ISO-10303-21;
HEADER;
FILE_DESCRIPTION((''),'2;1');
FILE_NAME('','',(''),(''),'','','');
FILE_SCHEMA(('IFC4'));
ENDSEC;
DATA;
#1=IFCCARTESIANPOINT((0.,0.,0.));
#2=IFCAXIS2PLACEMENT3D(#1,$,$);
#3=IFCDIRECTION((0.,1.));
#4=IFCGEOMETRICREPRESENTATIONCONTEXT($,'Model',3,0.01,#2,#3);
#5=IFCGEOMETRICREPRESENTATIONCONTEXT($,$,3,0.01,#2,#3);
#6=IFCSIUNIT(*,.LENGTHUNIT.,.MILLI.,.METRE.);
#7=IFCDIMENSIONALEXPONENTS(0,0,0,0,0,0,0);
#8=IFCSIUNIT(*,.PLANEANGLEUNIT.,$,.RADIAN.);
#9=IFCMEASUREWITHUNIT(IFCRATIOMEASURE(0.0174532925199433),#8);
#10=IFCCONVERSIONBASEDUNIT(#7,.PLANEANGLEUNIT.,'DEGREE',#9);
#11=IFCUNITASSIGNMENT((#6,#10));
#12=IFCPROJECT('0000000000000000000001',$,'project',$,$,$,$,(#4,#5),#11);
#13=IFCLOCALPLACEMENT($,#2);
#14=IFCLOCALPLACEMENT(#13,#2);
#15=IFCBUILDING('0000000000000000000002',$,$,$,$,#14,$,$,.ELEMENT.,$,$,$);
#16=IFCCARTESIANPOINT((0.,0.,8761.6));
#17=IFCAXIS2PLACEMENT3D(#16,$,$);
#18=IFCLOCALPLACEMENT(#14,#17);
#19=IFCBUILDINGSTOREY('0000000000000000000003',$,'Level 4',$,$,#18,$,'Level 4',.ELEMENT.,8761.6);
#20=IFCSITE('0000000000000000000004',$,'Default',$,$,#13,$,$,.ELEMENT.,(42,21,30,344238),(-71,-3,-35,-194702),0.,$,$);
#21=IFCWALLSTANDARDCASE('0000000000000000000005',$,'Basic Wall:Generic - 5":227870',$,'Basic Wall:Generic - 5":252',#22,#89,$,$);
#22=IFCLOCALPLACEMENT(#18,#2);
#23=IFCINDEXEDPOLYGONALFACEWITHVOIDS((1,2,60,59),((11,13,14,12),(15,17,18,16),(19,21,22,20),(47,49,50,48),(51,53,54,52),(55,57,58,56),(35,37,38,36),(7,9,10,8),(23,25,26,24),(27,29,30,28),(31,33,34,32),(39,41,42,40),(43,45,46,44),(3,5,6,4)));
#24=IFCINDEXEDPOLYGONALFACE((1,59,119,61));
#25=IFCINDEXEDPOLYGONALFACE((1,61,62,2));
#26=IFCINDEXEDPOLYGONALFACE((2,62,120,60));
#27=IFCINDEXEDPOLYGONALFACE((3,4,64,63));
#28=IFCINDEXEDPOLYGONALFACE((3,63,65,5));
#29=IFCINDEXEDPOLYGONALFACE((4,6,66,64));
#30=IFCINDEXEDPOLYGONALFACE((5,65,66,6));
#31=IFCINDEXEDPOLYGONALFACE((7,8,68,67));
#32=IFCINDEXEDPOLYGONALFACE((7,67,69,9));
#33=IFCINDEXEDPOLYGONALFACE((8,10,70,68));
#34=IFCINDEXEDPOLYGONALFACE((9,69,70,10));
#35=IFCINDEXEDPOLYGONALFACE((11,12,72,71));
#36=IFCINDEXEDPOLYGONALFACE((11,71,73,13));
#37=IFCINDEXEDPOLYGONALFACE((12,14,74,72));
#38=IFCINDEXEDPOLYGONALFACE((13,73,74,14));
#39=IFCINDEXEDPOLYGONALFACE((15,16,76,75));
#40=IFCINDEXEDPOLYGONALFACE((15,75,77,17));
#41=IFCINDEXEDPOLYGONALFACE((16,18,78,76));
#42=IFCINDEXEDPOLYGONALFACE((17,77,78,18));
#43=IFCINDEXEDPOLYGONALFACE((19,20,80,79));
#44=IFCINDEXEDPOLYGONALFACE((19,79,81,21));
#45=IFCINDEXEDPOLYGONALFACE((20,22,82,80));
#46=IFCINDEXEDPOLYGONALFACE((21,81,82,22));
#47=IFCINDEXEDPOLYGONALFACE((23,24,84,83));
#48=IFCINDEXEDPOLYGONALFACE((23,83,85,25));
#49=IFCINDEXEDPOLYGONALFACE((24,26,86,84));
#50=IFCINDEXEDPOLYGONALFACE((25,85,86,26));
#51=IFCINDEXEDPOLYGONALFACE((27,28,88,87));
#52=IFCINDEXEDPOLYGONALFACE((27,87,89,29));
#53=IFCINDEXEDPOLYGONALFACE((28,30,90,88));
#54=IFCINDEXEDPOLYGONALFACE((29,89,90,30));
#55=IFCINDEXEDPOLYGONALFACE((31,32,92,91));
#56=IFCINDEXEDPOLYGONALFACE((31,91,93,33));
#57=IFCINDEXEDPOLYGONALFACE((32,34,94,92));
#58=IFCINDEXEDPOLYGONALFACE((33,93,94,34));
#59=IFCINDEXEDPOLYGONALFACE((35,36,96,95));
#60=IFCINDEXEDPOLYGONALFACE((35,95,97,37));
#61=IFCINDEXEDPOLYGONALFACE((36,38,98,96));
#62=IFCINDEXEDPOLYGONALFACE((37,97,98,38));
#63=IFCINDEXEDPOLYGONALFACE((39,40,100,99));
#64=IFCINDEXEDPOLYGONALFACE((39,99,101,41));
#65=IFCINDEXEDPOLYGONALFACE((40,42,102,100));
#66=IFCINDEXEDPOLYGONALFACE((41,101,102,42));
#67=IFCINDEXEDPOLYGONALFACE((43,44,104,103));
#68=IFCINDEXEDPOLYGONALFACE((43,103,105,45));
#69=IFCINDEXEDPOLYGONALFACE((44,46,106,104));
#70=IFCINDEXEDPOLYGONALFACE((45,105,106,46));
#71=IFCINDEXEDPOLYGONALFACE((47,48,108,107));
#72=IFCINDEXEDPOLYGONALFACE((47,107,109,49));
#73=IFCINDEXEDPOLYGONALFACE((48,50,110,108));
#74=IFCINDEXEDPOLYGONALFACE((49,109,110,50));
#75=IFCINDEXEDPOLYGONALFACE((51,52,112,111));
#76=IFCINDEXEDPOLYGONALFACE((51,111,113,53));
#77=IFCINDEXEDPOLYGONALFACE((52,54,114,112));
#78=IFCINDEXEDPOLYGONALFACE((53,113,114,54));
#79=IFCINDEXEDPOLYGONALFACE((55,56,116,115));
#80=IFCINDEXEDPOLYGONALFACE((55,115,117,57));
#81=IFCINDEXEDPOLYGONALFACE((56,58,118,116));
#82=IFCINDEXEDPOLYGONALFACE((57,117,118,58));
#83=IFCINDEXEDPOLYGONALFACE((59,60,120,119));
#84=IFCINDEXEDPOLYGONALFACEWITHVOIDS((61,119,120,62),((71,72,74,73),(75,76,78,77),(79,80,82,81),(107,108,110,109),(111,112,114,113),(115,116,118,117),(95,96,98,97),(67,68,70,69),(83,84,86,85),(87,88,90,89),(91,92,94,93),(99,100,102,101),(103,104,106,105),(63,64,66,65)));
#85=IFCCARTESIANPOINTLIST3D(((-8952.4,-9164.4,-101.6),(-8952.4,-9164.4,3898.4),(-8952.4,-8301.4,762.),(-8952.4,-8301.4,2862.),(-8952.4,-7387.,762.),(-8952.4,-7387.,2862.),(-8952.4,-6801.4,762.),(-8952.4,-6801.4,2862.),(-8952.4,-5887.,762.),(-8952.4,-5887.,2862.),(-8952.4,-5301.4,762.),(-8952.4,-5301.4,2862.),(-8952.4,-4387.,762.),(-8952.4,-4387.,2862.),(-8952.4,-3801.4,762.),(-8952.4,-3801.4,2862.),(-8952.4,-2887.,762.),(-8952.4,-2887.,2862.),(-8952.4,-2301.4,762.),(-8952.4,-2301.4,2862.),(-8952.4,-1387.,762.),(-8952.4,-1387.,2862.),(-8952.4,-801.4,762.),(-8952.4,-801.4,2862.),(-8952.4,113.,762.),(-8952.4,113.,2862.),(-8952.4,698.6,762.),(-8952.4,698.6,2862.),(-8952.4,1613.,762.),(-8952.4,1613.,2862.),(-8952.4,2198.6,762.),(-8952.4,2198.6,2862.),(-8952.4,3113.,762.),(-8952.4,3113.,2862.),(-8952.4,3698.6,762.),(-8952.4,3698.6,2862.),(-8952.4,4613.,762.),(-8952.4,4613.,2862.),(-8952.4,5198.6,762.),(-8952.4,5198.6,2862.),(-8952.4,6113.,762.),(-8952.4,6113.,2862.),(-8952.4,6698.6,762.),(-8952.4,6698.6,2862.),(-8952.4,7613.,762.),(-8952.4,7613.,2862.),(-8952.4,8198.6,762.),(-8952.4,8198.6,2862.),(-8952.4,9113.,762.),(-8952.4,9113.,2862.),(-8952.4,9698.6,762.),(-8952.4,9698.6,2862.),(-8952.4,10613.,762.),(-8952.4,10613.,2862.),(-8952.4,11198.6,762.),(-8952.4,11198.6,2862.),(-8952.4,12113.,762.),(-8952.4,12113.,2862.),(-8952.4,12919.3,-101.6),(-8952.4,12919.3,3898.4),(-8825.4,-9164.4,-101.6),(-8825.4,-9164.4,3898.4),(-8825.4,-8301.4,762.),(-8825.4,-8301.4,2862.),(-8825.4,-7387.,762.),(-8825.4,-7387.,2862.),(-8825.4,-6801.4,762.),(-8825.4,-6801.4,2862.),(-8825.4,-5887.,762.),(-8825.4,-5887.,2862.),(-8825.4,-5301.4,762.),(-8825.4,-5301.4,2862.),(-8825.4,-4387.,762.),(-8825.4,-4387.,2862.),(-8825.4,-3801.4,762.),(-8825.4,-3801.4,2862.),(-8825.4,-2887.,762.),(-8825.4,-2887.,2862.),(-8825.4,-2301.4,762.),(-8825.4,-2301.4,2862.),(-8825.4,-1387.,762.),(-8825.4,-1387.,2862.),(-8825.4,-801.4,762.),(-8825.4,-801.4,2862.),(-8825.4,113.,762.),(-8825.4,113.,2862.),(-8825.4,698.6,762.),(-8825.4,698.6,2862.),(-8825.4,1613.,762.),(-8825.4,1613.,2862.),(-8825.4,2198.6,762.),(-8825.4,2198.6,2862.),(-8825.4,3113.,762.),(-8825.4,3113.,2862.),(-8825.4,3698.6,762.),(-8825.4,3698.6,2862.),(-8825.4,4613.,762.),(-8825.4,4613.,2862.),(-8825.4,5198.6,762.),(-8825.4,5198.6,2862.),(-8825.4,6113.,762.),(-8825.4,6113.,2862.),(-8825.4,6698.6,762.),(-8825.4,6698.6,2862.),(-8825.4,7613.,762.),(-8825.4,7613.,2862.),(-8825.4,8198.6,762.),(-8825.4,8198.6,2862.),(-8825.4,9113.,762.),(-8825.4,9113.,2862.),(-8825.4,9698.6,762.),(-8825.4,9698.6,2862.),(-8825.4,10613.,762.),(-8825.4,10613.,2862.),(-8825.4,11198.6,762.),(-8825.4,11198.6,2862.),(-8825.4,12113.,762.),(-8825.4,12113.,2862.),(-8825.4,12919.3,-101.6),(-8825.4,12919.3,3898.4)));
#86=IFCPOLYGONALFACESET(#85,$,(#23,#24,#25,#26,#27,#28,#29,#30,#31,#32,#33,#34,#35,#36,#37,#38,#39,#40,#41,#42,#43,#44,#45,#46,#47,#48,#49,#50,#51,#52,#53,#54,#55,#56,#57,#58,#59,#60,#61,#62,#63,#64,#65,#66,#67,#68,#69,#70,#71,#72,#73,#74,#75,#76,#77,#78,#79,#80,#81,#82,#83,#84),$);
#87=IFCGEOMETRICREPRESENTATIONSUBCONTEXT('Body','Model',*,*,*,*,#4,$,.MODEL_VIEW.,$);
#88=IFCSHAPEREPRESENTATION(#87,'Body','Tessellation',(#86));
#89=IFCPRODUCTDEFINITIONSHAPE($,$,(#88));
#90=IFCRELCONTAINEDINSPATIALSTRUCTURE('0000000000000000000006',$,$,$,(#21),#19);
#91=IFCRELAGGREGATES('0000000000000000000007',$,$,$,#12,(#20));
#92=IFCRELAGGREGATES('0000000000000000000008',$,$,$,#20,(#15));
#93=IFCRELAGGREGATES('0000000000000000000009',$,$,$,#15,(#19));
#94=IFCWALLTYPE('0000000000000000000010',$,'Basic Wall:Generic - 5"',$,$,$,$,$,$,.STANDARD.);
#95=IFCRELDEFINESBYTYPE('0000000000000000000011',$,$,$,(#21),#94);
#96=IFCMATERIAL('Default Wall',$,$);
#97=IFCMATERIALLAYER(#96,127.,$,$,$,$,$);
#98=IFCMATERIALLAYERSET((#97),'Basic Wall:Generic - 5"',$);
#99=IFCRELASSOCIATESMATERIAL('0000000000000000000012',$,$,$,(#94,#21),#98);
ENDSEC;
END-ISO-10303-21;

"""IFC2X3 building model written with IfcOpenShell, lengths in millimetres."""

from ifc_helpers import new_model, entity, si_unit, converted_unit, direction, frame, frame_2d, origin, place, context, subcontext, project, spatial, polyline, rectangle, extrude, clip, bounded_halfspace, material, layer, layer_set, layer_usage, type_object, element, save


model = new_model("IFC2X3")

# Units and contexts
model_context = context("Model", 3, precision=0.01, world=origin(), true_north=direction((0.0, 1.0)))
context_of_model = context(None, 3, precision=0.01, world=origin(), true_north=direction((0.0, 1.0)))
body_context = subcontext(model_context, "Body", "Model", "MODEL_VIEW")
ifc_project = project(units=[si_unit("LENGTHUNIT", "METRE", prefix="MILLI"), converted_unit("PLANEANGLEUNIT", "DEGREE", entity("IfcRatioMeasure", 0.0174532925199433), si_unit("PLANEANGLEUNIT", "RADIAN"), dimensions=[0, 0, 0, 0, 0, 0, 0])], contexts=[model_context, context_of_model])

# Site, building, storey
site_placement = place(None, origin())
site = spatial("IfcSite", under=ifc_project, at=site_placement, Name="Default", CompositionType="ELEMENT", RefLatitude=(42, 21, 30, 344238), RefLongitude=(-71, -3, -35, -194702), RefElevation=0.0)
building_placement = place(site_placement, origin())
building = spatial("IfcBuilding", under=site, at=building_placement, CompositionType="ELEMENT")
storey_placement = place(building_placement, frame((0.0, 0.0, 8761.6)))
storey = spatial("IfcBuildingStorey", under=building, at=storey_placement, Name="Level 4", LongName="Level 4", CompositionType="ELEMENT", Elevation=8761.6)

# Wall, openings
ifc_material = material(Name="Default Wall")
ifc_layer = layer(ifc_material, 127.0)
ifc_layer_set = layer_set([ifc_layer], Name="Basic Wall:Generic - 5\"")
ifc_layer_usage_1 = layer_usage(ifc_layer_set, "AXIS2", "NEGATIVE", 63.5)
wall_type = type_object("IfcWallType", Name="Basic Wall:Generic - 5\"", PredefinedType="STANDARD", material=ifc_layer_set)
wall_1_placement = place(storey_placement, frame((-8888.9, -9164.4, -101.6), z_axis=(0.0, 0.0, 1.0), x_axis=(0.0, 1.0, 0.0)))
wall_1 = element("IfcWallStandardCase", 1, at=wall_1_placement, inside=storey, type_object=wall_type, material=ifc_layer_usage_1, Name="Basic Wall:Generic - 5\":227870", ObjectType="Basic Wall:Generic - 5\":252", context=body_context, shape_type="Clipping", body=[
    clip(extrude(rectangle(XDim=22083.7, YDim=127.0, at=frame_2d((11041.9, 0.0), x_axis=(-1.0, 0.0))), origin(), (0.0, 0.0, 1.0), 4000.0), bounded_halfspace(frame((0.0, -63.5, 4000.0), z_axis=(0.0, 0.0, -1.0), x_axis=(-1.0, 0.0, 0.0)), True, frame((0.0, -63.5, 4000.0)), polyline([(0.0, 0.0), (127.0, 0.0), (21956.7, 0.0), (22083.7, 0.0), (22083.7, 127.0), (0.0, 127.0), (0.0, 0.0)]))),
])
opening_1_placement = place(wall_1_placement, frame((21277.4, 63.5, 863.6)))
element("IfcOpeningElement", 2, at=opening_1_placement, cuts=wall_1, ObjectType="Opening", context=body_context, shape_type="SweptSolid", body=[
    extrude(rectangle(XDim=2100.0, YDim=914.4, at=frame_2d((1050.0, 457.2), x_axis=(-1.0, 0.0))), frame((0.0, 0.0, 0.0), z_axis=(0.0, -1.0, 0.0), x_axis=(0.0, 0.0, 1.0)), (0.0, 0.0, 1.0), 127.0),
])
opening_2_placement = place(wall_1_placement, frame((18277.4, 63.5, 863.6)))
element("IfcOpeningElement", 3, at=opening_2_placement, cuts=wall_1, ObjectType="Opening", context=body_context, shape_type="SweptSolid", body=[
    extrude(rectangle(XDim=2100.0, YDim=914.4, at=frame_2d((1050.0, 457.2), x_axis=(-1.0, 0.0))), frame((0.0, 0.0, 0.0), z_axis=(0.0, -1.0, 0.0), x_axis=(0.0, 0.0, 1.0)), (0.0, 0.0, 1.0), 127.0),
])
opening_3_placement = place(wall_1_placement, frame((15277.4, 63.5, 863.6)))
element("IfcOpeningElement", 4, at=opening_3_placement, cuts=wall_1, ObjectType="Opening", context=body_context, shape_type="SweptSolid", body=[
    extrude(rectangle(XDim=2100.0, YDim=914.4, at=frame_2d((1050.0, 457.2), x_axis=(-1.0, 0.0))), frame((0.0, 0.0, 0.0), z_axis=(0.0, -1.0, 0.0), x_axis=(0.0, 0.0, 1.0)), (0.0, 0.0, 1.0), 127.0),
])
opening_4_placement = place(wall_1_placement, frame((12277.4, 63.5, 863.6)))
element("IfcOpeningElement", 5, at=opening_4_placement, cuts=wall_1, ObjectType="Opening", context=body_context, shape_type="SweptSolid", body=[
    extrude(rectangle(XDim=2100.0, YDim=914.4, at=frame_2d((1050.0, 457.2), x_axis=(-1.0, 0.0))), frame((0.0, 0.0, 0.0), z_axis=(0.0, -1.0, 0.0), x_axis=(0.0, 0.0, 1.0)), (0.0, 0.0, 1.0), 127.0),
])
opening_5_placement = place(wall_1_placement, frame((9277.4, 63.5, 863.6)))
element("IfcOpeningElement", 6, at=opening_5_placement, cuts=wall_1, ObjectType="Opening", context=body_context, shape_type="SweptSolid", body=[
    extrude(rectangle(XDim=2100.0, YDim=914.4, at=frame_2d((1050.0, 457.2), x_axis=(-1.0, 0.0))), frame((0.0, 0.0, 0.0), z_axis=(0.0, -1.0, 0.0), x_axis=(0.0, 0.0, 1.0)), (0.0, 0.0, 1.0), 127.0),
])
opening_6_placement = place(wall_1_placement, frame((6277.4, 63.5, 863.6)))
element("IfcOpeningElement", 7, at=opening_6_placement, cuts=wall_1, ObjectType="Opening", context=body_context, shape_type="SweptSolid", body=[
    extrude(rectangle(XDim=2100.0, YDim=914.4, at=frame_2d((1050.0, 457.2), x_axis=(-1.0, 0.0))), frame((0.0, 0.0, 0.0), z_axis=(0.0, -1.0, 0.0), x_axis=(0.0, 0.0, 1.0)), (0.0, 0.0, 1.0), 127.0),
])
opening_7_placement = place(wall_1_placement, frame((3277.4, 63.5, 863.6)))
element("IfcOpeningElement", 8, at=opening_7_placement, cuts=wall_1, ObjectType="Opening", context=body_context, shape_type="SweptSolid", body=[
    extrude(rectangle(XDim=2100.0, YDim=914.4, at=frame_2d((1050.0, 457.2), x_axis=(-1.0, 0.0))), frame((0.0, 0.0, 0.0), z_axis=(0.0, -1.0, 0.0), x_axis=(0.0, 0.0, 1.0)), (0.0, 0.0, 1.0), 127.0),
])
opening_8_placement = place(wall_1_placement, frame((19777.4, 63.5, 863.6)))
element("IfcOpeningElement", 9, at=opening_8_placement, cuts=wall_1, ObjectType="Opening", context=body_context, shape_type="SweptSolid", body=[
    extrude(rectangle(XDim=2100.0, YDim=914.4, at=frame_2d((1050.0, 457.2), x_axis=(-1.0, 0.0))), frame((0.0, 0.0, 0.0), z_axis=(0.0, -1.0, 0.0), x_axis=(0.0, 0.0, 1.0)), (0.0, 0.0, 1.0), 127.0),
])
opening_9_placement = place(wall_1_placement, frame((16777.4, 63.5, 863.6)))
element("IfcOpeningElement", 10, at=opening_9_placement, cuts=wall_1, ObjectType="Opening", context=body_context, shape_type="SweptSolid", body=[
    extrude(rectangle(XDim=2100.0, YDim=914.4, at=frame_2d((1050.0, 457.2), x_axis=(-1.0, 0.0))), frame((0.0, 0.0, 0.0), z_axis=(0.0, -1.0, 0.0), x_axis=(0.0, 0.0, 1.0)), (0.0, 0.0, 1.0), 127.0),
])
opening_10_placement = place(wall_1_placement, frame((13777.4, 63.5, 863.6)))
element("IfcOpeningElement", 11, at=opening_10_placement, cuts=wall_1, ObjectType="Opening", context=body_context, shape_type="SweptSolid", body=[
    extrude(rectangle(XDim=2100.0, YDim=914.4, at=frame_2d((1050.0, 457.2), x_axis=(-1.0, 0.0))), frame((0.0, 0.0, 0.0), z_axis=(0.0, -1.0, 0.0), x_axis=(0.0, 0.0, 1.0)), (0.0, 0.0, 1.0), 127.0),
])
opening_11_placement = place(wall_1_placement, frame((10777.4, 63.5, 863.6)))
element("IfcOpeningElement", 12, at=opening_11_placement, cuts=wall_1, ObjectType="Opening", context=body_context, shape_type="SweptSolid", body=[
    extrude(rectangle(XDim=2100.0, YDim=914.4, at=frame_2d((1050.0, 457.2), x_axis=(-1.0, 0.0))), frame((0.0, 0.0, 0.0), z_axis=(0.0, -1.0, 0.0), x_axis=(0.0, 0.0, 1.0)), (0.0, 0.0, 1.0), 127.0),
])
opening_12_placement = place(wall_1_placement, frame((7777.4, 63.5, 863.6)))
element("IfcOpeningElement", 13, at=opening_12_placement, cuts=wall_1, ObjectType="Opening", context=body_context, shape_type="SweptSolid", body=[
    extrude(rectangle(XDim=2100.0, YDim=914.4, at=frame_2d((1050.0, 457.2), x_axis=(-1.0, 0.0))), frame((0.0, 0.0, 0.0), z_axis=(0.0, -1.0, 0.0), x_axis=(0.0, 0.0, 1.0)), (0.0, 0.0, 1.0), 127.0),
])
opening_13_placement = place(wall_1_placement, frame((4777.4, 63.5, 863.6)))
element("IfcOpeningElement", 14, at=opening_13_placement, cuts=wall_1, ObjectType="Opening", context=body_context, shape_type="SweptSolid", body=[
    extrude(rectangle(XDim=2100.0, YDim=914.4, at=frame_2d((1050.0, 457.2), x_axis=(-1.0, 0.0))), frame((0.0, 0.0, 0.0), z_axis=(0.0, -1.0, 0.0), x_axis=(0.0, 0.0, 1.0)), (0.0, 0.0, 1.0), 127.0),
])
opening_14_placement = place(wall_1_placement, frame((1777.4, 63.5, 863.6)))
element("IfcOpeningElement", 15, at=opening_14_placement, cuts=wall_1, ObjectType="Opening", context=body_context, shape_type="SweptSolid", body=[
    extrude(rectangle(XDim=2100.0, YDim=914.4, at=frame_2d((1050.0, 457.2), x_axis=(-1.0, 0.0))), frame((0.0, 0.0, 0.0), z_axis=(0.0, -1.0, 0.0), x_axis=(0.0, 0.0, 1.0)), (0.0, 0.0, 1.0), 127.0),
])

save(model, "model.ifc")
